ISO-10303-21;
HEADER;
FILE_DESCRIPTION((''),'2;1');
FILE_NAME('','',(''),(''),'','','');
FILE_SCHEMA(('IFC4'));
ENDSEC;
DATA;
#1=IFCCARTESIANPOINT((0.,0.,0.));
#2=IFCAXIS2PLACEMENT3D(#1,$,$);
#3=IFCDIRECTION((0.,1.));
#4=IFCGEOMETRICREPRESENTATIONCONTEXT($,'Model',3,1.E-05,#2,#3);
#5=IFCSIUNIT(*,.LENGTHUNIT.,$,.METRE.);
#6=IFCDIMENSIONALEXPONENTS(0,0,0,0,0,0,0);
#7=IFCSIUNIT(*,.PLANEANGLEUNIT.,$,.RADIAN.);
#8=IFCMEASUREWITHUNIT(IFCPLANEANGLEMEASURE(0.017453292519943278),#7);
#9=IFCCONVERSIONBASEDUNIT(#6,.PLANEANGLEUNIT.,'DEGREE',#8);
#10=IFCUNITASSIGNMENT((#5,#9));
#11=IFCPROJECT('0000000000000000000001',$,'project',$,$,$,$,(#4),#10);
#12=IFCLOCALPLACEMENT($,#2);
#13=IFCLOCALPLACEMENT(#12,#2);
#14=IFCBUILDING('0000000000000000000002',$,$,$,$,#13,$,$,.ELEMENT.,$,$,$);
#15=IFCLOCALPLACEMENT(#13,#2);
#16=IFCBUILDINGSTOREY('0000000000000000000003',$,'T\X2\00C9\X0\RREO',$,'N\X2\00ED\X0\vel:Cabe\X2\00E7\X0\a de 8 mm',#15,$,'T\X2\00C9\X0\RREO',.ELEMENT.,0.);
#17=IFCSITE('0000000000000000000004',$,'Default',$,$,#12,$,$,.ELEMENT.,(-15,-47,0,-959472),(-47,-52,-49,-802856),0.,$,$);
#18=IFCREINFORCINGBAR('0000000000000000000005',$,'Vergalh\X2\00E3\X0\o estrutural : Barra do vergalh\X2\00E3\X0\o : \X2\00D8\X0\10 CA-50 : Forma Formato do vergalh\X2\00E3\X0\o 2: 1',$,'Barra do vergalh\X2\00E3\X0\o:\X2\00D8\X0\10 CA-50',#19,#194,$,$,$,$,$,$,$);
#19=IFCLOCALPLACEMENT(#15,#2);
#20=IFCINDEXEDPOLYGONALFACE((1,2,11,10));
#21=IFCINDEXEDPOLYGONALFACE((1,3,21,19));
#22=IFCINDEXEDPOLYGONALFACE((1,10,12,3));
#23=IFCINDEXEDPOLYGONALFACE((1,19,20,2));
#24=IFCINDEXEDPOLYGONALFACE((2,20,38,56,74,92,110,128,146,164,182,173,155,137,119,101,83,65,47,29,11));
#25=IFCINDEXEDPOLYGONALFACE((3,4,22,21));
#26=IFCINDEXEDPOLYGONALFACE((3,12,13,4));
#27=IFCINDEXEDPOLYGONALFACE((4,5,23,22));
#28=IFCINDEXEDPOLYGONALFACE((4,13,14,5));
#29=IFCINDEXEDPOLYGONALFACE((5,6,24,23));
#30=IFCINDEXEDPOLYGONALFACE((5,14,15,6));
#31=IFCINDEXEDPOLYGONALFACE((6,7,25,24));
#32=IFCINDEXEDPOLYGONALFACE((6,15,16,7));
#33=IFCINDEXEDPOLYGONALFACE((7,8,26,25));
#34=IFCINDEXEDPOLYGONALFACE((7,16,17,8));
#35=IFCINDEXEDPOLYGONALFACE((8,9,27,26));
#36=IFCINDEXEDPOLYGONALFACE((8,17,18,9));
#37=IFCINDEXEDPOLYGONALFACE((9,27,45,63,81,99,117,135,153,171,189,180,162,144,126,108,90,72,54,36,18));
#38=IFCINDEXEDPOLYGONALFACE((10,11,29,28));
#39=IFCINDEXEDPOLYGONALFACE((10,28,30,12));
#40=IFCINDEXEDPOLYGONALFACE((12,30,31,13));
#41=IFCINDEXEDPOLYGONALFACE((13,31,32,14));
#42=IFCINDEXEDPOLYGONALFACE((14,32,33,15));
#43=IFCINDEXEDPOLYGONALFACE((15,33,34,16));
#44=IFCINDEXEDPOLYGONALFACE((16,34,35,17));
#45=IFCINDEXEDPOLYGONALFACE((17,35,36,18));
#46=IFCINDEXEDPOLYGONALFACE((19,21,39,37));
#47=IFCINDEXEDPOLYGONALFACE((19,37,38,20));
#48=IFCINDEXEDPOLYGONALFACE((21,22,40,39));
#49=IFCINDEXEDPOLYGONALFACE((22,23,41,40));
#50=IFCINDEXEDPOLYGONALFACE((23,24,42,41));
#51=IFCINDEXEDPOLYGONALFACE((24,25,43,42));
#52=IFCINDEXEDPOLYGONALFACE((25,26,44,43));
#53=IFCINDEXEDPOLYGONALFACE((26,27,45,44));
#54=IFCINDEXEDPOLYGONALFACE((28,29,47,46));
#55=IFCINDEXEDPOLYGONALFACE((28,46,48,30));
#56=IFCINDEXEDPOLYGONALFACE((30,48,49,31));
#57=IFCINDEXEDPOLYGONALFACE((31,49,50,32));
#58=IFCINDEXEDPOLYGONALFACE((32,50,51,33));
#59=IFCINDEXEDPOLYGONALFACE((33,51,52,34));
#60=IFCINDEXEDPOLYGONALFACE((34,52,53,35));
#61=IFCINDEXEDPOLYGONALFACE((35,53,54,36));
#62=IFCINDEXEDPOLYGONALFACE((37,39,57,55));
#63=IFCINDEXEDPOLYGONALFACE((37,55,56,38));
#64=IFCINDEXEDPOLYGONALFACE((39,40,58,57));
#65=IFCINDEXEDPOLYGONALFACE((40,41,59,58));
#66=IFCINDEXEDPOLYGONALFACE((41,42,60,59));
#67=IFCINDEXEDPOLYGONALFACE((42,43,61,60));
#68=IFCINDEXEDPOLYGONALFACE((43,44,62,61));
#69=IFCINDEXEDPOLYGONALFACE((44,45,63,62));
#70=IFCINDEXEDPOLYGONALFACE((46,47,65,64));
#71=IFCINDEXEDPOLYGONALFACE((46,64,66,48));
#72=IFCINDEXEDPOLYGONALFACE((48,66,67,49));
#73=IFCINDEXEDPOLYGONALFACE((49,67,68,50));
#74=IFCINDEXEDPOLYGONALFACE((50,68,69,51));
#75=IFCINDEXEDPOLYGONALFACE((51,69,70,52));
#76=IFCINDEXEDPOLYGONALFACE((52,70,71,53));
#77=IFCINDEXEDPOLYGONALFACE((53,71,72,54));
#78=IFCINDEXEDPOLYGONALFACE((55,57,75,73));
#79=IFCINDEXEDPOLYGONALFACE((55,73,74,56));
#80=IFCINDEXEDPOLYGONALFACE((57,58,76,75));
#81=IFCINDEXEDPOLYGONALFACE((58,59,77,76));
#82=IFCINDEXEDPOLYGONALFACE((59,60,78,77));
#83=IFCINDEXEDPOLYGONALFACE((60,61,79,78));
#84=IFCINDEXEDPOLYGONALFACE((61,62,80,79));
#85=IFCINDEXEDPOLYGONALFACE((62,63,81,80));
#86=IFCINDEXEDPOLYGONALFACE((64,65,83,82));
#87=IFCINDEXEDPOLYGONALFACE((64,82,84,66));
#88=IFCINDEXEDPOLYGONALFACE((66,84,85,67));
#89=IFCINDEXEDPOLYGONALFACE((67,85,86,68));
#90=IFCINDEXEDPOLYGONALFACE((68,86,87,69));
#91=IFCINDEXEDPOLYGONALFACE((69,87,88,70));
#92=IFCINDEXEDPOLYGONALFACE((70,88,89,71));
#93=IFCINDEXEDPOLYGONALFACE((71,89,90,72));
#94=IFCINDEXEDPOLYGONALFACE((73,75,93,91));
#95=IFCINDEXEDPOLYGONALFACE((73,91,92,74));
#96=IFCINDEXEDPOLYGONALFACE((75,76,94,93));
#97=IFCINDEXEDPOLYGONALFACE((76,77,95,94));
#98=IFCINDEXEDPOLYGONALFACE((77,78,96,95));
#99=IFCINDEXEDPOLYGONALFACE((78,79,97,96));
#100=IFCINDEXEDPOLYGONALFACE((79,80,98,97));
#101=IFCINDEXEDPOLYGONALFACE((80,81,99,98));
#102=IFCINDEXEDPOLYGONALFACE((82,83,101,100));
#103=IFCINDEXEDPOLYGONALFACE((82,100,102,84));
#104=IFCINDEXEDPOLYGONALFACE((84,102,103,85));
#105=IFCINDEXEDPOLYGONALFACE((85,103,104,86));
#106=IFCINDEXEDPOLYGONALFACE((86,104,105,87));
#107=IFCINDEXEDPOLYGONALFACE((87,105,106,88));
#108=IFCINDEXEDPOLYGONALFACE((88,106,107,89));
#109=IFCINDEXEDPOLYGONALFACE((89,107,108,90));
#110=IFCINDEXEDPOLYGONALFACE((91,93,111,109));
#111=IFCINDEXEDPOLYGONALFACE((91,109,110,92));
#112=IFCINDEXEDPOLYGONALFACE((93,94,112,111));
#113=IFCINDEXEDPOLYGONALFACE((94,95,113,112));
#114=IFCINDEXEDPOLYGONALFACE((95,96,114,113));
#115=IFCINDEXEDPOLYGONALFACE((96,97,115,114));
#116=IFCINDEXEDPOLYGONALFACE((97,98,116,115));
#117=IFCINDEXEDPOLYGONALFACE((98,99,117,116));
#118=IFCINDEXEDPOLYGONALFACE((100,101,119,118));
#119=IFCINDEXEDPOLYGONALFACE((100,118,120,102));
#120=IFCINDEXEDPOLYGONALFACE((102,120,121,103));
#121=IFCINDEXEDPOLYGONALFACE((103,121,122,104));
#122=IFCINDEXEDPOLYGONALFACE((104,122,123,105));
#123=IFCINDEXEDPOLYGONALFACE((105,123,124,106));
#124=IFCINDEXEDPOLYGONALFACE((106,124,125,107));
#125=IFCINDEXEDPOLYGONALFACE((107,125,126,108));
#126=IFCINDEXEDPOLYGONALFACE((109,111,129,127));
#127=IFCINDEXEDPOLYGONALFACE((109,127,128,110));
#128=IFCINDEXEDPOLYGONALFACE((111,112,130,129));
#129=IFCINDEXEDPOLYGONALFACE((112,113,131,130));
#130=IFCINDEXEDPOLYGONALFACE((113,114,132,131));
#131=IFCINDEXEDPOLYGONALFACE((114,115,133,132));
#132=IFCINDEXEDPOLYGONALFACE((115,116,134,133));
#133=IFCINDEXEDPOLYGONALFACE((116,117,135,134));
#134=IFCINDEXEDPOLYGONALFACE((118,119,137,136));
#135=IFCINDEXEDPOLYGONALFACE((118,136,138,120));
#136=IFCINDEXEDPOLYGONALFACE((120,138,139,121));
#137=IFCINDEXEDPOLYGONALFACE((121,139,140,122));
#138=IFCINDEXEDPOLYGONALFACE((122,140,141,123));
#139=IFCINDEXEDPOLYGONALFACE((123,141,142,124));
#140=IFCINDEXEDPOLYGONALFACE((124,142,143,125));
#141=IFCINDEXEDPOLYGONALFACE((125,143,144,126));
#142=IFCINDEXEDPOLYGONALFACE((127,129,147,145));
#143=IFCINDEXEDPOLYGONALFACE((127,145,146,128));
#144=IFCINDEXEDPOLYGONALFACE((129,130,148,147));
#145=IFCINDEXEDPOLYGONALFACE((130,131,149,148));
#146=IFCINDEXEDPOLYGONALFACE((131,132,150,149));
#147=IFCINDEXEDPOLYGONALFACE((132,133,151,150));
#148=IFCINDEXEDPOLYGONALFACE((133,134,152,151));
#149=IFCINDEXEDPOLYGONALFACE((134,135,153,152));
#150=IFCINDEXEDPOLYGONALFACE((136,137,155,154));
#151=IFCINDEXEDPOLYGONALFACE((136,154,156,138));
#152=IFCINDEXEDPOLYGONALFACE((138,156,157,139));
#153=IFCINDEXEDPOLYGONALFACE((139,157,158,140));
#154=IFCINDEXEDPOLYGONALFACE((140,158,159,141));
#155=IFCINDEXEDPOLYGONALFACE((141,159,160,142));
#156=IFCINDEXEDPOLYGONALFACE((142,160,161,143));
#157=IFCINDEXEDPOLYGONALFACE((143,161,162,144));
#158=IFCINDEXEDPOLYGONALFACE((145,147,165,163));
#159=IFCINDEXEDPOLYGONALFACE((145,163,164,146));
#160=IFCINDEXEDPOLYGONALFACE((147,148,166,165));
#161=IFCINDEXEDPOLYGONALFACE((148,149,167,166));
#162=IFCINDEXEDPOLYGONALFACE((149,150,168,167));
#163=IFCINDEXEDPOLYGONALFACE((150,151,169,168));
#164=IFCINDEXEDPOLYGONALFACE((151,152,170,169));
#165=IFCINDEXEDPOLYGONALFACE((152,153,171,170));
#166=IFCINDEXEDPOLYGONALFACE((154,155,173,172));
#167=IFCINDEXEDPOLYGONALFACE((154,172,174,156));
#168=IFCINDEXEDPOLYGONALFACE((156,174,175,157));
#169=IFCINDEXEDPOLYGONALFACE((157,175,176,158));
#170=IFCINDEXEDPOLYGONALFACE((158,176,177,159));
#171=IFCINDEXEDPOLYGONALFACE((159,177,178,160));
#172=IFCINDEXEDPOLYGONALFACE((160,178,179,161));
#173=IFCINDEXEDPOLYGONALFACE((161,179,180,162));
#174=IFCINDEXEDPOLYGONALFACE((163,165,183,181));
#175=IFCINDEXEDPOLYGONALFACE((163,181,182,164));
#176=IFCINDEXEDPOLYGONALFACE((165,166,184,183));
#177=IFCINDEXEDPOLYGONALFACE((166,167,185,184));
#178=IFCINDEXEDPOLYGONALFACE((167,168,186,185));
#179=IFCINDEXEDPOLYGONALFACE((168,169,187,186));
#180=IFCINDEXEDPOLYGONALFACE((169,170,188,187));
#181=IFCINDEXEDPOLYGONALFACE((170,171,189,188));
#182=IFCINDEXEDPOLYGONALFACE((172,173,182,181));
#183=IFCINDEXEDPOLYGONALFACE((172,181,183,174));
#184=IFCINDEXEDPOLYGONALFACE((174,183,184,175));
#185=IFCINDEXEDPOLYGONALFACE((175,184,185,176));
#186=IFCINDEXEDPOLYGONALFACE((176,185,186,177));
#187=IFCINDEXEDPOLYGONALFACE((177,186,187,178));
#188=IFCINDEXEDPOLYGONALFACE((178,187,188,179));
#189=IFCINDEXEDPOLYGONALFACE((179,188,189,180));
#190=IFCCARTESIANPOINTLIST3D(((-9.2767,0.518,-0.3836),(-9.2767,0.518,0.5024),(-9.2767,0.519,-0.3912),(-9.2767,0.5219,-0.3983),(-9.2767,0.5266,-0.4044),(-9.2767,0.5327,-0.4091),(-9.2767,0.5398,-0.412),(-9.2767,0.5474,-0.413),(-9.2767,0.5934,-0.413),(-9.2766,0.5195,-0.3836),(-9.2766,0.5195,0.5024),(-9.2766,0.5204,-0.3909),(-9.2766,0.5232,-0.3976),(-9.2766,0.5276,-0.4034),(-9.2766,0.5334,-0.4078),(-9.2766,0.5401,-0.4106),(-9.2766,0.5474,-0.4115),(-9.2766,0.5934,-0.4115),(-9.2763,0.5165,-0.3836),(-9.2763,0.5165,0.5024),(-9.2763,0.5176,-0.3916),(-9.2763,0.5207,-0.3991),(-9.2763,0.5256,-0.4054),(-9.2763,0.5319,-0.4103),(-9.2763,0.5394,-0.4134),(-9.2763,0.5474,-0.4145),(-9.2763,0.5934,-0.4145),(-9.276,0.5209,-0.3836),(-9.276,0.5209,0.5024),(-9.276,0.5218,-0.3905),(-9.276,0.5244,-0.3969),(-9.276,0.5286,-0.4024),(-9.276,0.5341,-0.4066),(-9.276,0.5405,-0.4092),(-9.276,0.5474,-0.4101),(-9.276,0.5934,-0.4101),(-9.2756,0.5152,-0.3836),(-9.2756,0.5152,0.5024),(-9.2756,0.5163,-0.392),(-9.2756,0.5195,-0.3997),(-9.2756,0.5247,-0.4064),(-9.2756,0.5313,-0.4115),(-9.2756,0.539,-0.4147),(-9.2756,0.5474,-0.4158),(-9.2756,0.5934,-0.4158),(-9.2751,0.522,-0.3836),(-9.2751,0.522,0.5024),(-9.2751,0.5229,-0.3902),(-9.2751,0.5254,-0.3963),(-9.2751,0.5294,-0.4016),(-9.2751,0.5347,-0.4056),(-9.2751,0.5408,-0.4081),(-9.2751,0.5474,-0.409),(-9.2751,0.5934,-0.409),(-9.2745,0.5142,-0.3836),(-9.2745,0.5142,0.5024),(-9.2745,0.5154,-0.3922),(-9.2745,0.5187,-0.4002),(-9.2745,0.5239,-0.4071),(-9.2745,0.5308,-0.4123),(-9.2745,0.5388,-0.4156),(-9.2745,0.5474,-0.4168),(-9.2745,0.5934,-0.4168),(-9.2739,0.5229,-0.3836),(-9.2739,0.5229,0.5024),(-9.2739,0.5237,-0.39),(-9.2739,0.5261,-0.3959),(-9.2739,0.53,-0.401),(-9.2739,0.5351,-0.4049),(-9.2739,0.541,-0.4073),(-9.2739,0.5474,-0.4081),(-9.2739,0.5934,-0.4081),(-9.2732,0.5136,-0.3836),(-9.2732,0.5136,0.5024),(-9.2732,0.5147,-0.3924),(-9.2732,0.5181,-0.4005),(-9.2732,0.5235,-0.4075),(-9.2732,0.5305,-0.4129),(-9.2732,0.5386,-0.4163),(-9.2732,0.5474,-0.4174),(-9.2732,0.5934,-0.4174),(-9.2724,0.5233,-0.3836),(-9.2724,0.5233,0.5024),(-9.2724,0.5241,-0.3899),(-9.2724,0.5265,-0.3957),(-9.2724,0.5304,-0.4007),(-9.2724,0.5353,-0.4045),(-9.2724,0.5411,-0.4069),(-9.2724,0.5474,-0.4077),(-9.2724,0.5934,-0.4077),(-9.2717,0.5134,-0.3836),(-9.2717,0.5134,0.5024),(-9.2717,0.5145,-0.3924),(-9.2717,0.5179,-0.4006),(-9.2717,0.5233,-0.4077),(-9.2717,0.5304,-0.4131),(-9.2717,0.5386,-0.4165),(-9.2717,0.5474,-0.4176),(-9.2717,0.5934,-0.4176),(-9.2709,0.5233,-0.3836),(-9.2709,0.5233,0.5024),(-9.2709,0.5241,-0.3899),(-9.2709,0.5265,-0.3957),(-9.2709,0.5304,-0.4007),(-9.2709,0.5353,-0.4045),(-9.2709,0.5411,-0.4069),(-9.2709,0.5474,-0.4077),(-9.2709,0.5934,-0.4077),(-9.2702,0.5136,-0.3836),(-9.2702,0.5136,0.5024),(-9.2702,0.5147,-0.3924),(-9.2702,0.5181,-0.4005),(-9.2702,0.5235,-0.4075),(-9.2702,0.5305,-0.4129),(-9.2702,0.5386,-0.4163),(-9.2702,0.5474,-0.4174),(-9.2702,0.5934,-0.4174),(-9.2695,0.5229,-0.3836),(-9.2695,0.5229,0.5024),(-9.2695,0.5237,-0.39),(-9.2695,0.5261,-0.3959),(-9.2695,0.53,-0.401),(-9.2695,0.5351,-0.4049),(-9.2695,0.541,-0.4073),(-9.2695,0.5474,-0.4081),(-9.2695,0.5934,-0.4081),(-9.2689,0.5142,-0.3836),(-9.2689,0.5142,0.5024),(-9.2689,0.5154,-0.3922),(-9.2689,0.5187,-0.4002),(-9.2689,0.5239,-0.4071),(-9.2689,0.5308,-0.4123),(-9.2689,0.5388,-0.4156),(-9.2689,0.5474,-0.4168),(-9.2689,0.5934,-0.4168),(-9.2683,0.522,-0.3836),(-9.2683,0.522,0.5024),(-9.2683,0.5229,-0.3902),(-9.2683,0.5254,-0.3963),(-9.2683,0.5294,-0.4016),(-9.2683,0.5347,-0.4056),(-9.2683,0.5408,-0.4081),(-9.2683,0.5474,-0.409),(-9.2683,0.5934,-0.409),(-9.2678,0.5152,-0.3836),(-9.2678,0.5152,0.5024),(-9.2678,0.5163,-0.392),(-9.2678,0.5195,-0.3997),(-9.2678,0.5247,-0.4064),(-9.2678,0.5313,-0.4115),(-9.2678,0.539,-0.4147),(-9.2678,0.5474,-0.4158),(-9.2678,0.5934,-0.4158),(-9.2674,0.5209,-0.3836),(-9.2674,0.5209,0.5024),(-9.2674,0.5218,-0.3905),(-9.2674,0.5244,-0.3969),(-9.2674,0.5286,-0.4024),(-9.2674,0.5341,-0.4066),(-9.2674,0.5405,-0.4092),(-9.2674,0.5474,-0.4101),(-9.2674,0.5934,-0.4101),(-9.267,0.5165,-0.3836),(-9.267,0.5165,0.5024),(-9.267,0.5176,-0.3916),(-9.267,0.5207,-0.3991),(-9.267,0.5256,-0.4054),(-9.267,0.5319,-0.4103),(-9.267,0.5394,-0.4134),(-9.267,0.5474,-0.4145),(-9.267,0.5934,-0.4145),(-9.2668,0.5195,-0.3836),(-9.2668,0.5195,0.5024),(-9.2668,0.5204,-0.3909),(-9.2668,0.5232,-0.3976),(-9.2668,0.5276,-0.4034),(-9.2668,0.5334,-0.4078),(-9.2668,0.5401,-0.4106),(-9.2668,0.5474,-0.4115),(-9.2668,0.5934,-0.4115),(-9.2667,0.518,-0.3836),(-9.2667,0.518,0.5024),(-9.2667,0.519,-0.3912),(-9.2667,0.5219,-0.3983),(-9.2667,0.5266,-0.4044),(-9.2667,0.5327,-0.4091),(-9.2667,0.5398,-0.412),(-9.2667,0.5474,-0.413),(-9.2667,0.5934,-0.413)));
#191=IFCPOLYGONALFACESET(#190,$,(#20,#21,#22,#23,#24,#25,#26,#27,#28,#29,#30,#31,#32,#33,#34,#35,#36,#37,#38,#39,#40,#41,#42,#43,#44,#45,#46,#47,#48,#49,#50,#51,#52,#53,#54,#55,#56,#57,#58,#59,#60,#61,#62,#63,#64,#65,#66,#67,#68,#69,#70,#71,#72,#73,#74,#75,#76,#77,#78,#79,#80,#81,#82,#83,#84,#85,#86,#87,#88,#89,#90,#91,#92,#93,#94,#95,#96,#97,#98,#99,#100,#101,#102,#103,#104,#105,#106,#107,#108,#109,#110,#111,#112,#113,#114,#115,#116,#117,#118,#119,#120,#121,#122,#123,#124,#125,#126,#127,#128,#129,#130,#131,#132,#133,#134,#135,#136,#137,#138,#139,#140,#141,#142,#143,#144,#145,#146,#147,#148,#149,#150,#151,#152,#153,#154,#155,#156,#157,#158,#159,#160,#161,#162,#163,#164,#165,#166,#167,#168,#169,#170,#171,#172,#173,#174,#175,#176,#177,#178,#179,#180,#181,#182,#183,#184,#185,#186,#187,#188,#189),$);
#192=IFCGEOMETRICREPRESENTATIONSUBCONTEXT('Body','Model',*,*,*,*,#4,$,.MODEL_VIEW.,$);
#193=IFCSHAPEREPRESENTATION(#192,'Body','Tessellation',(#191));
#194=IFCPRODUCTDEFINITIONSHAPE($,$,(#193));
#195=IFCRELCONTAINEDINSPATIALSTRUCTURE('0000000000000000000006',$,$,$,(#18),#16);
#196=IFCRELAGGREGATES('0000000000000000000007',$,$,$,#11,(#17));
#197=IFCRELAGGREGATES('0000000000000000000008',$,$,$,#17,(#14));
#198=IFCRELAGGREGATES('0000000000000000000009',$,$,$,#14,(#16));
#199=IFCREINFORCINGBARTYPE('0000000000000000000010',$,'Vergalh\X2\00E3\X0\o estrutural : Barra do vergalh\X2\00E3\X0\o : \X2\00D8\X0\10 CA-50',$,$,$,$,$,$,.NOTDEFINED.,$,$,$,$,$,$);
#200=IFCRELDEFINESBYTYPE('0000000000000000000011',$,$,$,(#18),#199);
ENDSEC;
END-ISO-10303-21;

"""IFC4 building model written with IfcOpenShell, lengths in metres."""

from ifc_helpers import new_model, entity, si_unit, converted_unit, direction, origin, place, context, subcontext, project, spatial, type_object, element, save


model = new_model("IFC4")

# Units and contexts
model_context = context("Model", 3, precision=1e-05, world=origin(), true_north=direction((0.0, 1.0)))
body_context = subcontext(model_context, "Body", "Model", "MODEL_VIEW")
ifc_project = project(units=[si_unit("LENGTHUNIT", "METRE"), converted_unit("PLANEANGLEUNIT", "DEGREE", entity("IfcPlaneAngleMeasure", 0.017453292519943278), si_unit("PLANEANGLEUNIT", "RADIAN"), dimensions=[0, 0, 0, 0, 0, 0, 0])], contexts=[model_context])

# Site, building, storey
site_placement = place(None, origin())
site = spatial("IfcSite", under=ifc_project, at=site_placement, Name="Default", CompositionType="ELEMENT", RefLatitude=(-15, -47, 0, -959472), RefLongitude=(-47, -52, -49, -802856), RefElevation=0.0)
building_placement = place(site_placement, origin())
building = spatial("IfcBuilding", under=site, at=building_placement, CompositionType="ELEMENT")
storey_placement = place(building_placement, origin())
storey = spatial("IfcBuildingStorey", under=building, at=storey_placement, Name="TÉRREO", ObjectType="Nível:Cabeça de 8 mm", LongName="TÉRREO", CompositionType="ELEMENT", Elevation=0.0)

# Reinforcing bar
reinforcing_bar_type_1 = type_object("IfcReinforcingBarType", Name="Vergalhão estrutural : Barra do vergalhão : Ø10 CA-50", PredefinedType="NOTDEFINED")
reinforcing_bar_1_placement = place(storey_placement, origin())
element("IfcReinforcingBar", 1, at=reinforcing_bar_1_placement, inside=storey, type_object=reinforcing_bar_type_1, Name="Vergalhão estrutural : Barra do vergalhão : Ø10 CA-50 : Forma Formato do vergalhão 2: 1", ObjectType="Barra do vergalhão:Ø10 CA-50", context=body_context, shape_type="AdvancedSweptSolid", body=[
    entity("IfcSweptDiskSolid", entity("IfcIndexedPolyCurve", entity("IfcCartesianPointList3D", [[-9.2717, 0.5934, -0.4126], [-9.2717, 0.5474, -0.4126], [-9.2717, 0.5269, -0.4042], [-9.2717, 0.5184, -0.3836], [-9.2717, 0.5184, 0.5024]]), [entity("IfcLineIndex", [1, 2]), entity("IfcArcIndex", [2, 3, 4]), entity("IfcLineIndex", [4, 5])], False), 0.005, None, 0.0, 92.0),
])

save(model, "model.ifc")
